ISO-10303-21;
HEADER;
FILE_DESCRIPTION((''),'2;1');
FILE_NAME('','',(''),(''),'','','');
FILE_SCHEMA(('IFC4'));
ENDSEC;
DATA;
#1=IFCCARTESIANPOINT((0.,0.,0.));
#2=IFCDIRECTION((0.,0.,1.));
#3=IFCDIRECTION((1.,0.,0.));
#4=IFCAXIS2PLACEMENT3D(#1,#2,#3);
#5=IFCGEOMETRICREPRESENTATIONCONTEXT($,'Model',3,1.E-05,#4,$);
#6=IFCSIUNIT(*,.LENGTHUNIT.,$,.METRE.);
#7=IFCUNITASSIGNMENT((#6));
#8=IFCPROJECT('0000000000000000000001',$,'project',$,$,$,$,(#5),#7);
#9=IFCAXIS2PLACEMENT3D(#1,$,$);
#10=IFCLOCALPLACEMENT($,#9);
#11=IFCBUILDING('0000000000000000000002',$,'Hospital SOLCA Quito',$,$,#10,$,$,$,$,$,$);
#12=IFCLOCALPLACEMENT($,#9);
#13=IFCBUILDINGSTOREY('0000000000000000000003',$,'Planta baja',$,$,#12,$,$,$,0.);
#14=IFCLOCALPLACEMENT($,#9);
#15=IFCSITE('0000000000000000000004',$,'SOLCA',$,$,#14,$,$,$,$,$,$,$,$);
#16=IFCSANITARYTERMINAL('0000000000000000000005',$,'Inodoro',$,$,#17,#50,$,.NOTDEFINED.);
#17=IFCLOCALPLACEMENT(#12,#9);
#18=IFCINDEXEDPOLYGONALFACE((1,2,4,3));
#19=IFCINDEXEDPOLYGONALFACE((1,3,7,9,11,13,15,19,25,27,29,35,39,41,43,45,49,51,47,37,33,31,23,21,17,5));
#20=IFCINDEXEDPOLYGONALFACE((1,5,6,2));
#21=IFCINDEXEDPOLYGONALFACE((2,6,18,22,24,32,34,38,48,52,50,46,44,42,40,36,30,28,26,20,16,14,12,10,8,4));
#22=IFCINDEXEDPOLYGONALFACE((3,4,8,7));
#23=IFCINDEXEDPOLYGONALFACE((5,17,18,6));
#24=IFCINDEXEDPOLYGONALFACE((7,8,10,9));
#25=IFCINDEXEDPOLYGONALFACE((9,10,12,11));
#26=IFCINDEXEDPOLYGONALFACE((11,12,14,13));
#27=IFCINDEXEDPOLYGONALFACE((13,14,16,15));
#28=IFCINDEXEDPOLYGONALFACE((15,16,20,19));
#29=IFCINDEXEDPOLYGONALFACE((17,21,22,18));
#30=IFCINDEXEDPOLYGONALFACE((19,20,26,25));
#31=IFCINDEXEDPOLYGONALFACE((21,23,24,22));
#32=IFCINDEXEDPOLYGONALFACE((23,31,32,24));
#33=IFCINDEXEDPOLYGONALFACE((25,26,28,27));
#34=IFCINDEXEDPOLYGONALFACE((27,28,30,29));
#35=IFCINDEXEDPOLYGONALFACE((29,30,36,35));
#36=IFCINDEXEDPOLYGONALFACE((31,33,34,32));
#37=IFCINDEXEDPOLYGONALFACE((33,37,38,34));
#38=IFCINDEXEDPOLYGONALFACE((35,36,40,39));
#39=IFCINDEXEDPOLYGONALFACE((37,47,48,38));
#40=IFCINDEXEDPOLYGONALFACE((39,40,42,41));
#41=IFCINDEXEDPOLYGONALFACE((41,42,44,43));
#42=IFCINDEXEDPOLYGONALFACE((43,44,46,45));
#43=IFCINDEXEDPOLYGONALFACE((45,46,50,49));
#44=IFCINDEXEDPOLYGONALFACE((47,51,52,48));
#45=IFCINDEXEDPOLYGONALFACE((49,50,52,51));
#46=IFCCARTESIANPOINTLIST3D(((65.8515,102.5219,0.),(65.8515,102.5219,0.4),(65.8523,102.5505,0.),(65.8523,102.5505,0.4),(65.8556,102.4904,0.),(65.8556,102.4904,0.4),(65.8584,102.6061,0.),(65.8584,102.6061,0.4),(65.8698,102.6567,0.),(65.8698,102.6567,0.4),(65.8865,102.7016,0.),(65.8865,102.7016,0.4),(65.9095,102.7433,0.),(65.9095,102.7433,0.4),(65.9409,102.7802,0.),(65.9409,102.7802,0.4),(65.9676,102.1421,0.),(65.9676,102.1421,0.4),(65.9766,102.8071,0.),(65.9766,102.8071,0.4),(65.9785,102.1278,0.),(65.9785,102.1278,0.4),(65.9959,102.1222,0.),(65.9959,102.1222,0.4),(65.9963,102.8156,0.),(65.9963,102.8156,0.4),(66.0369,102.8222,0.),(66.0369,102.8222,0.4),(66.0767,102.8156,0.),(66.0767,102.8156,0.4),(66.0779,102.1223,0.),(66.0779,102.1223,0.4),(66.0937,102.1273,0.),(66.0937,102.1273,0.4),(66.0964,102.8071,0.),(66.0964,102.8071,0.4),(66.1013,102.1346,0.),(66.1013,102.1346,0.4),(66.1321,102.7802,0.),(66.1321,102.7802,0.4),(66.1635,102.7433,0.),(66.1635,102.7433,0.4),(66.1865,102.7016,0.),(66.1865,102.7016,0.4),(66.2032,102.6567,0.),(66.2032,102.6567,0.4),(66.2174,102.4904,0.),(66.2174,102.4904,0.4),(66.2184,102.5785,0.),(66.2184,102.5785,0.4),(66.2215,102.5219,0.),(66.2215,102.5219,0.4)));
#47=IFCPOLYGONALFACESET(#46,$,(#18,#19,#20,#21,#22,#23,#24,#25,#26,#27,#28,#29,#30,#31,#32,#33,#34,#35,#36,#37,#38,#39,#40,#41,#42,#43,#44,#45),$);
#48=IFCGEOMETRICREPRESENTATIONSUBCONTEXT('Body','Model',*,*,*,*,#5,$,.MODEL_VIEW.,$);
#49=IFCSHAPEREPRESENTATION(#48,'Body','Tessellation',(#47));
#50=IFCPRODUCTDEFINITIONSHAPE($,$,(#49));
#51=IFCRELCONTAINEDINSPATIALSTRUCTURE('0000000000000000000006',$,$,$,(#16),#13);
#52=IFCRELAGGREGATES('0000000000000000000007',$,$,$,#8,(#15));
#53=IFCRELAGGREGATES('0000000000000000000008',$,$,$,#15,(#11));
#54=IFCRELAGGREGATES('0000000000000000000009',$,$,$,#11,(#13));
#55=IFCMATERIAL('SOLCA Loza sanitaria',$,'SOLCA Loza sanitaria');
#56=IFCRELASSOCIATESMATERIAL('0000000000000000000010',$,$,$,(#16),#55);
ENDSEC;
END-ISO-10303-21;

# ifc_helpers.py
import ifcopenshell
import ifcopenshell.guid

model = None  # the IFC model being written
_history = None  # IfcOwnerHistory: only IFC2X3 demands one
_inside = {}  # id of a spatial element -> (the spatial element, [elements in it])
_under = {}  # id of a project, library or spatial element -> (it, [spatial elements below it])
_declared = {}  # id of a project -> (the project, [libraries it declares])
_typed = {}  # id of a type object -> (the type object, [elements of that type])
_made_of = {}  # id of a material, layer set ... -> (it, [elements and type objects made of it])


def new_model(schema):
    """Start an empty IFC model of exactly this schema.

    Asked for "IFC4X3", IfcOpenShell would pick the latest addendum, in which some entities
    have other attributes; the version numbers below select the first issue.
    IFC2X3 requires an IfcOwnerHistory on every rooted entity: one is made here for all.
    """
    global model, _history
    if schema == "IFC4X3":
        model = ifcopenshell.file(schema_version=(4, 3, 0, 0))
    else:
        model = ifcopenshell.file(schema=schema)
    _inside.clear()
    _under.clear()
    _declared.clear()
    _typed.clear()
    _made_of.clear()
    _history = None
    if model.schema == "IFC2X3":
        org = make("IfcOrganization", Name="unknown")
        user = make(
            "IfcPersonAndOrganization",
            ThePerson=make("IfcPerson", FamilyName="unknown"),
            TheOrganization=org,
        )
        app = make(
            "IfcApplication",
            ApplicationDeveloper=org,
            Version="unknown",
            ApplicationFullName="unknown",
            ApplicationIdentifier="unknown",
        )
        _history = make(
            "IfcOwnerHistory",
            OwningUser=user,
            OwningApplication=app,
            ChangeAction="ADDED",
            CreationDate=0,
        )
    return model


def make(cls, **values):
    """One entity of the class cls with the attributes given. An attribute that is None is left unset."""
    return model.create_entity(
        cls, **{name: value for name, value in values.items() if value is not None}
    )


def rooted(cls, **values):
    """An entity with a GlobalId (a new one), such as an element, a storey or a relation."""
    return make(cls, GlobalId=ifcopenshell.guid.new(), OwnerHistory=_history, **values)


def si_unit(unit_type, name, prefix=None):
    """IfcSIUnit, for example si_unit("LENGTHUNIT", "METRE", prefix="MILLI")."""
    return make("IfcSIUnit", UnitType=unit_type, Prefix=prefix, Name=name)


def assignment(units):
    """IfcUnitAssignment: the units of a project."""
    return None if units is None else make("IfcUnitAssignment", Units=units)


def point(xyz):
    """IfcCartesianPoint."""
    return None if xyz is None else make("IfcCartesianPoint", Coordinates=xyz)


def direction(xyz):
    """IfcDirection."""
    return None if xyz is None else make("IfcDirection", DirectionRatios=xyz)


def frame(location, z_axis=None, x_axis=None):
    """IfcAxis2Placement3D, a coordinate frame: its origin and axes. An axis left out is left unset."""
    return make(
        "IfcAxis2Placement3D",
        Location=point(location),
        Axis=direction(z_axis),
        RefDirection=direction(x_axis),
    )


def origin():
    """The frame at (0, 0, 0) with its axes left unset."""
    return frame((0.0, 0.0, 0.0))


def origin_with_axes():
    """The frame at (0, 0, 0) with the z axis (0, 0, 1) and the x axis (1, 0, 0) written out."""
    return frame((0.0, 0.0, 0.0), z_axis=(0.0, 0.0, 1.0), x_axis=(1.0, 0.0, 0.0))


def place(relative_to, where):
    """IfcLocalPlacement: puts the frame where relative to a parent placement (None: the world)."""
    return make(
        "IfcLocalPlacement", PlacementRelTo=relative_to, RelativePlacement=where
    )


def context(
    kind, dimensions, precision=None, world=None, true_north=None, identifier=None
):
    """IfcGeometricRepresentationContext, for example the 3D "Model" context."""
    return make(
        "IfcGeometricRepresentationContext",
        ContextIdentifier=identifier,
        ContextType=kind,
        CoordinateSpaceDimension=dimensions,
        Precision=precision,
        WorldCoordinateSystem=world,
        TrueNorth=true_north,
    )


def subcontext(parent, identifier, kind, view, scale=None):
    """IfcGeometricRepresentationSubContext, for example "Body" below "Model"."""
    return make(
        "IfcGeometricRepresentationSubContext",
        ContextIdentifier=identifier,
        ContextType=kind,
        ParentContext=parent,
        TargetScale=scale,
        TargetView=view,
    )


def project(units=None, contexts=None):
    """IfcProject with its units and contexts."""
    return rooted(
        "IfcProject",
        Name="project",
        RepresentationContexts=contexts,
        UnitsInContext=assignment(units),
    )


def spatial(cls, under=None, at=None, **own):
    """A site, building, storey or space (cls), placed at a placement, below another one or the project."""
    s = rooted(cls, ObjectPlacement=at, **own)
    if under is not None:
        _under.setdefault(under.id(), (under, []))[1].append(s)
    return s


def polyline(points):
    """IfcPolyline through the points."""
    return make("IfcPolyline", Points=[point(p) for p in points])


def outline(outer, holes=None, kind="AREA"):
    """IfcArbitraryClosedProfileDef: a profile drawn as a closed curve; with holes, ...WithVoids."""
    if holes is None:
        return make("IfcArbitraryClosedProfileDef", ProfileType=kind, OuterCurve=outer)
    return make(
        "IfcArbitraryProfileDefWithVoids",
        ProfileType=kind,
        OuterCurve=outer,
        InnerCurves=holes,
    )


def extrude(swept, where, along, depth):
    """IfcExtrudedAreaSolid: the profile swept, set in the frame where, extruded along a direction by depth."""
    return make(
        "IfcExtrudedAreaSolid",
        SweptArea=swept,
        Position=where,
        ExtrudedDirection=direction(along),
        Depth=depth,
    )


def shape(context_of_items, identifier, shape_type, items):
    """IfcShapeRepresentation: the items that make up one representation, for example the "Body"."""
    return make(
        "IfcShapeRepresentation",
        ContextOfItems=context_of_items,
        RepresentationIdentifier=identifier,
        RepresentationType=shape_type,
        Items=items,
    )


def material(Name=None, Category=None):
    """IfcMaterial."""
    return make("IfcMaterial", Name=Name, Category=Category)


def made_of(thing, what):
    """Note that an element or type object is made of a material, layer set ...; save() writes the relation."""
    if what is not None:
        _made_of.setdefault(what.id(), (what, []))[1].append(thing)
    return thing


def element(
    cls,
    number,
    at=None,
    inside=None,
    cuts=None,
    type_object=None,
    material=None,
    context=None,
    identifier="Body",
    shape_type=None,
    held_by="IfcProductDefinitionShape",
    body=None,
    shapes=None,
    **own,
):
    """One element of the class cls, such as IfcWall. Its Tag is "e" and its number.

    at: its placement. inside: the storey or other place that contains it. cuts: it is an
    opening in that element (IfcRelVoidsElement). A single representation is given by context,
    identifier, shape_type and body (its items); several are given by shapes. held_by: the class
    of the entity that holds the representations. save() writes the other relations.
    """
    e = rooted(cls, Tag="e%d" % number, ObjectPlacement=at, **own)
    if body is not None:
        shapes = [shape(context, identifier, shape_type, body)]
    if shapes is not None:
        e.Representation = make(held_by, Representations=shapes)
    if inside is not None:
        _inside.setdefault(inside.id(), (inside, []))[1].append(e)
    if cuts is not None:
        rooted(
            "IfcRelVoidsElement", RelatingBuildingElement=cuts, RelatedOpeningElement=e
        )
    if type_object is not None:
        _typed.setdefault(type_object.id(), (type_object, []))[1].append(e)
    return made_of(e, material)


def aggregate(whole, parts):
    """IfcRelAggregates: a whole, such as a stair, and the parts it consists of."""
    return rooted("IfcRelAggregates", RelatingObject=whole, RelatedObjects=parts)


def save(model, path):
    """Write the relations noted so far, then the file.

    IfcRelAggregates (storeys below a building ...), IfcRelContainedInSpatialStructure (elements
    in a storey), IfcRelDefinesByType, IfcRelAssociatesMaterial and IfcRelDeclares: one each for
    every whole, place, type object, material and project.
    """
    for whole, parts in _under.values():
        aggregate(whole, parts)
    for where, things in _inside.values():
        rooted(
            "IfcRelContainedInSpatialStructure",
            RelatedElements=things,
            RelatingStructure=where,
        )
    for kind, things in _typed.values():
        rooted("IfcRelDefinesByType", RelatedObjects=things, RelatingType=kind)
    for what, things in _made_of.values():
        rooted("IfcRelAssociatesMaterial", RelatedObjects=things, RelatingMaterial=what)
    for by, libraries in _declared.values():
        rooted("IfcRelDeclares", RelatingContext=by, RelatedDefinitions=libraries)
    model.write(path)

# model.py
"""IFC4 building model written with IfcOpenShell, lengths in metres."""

from ifc_helpers import new_model, si_unit, origin, origin_with_axes, place, context, subcontext, project, spatial, polyline, outline, extrude, material, element, save


model = new_model("IFC4")

# Units and contexts
model_context = context("Model", 3, precision=1e-05, world=origin_with_axes())
body_context = subcontext(model_context, "Body", "Model", "MODEL_VIEW")
ifc_project = project(units=[si_unit("LENGTHUNIT", "METRE")], contexts=[model_context])

# Site, building, storey
site_placement = place(None, origin())
site = spatial("IfcSite", under=ifc_project, at=site_placement, Name="SOLCA")
building_placement = place(None, origin())
building = spatial("IfcBuilding", under=site, at=building_placement, Name="Hospital SOLCA Quito")
storey_placement = place(None, origin())
storey = spatial("IfcBuildingStorey", under=building, at=storey_placement, Name="Planta baja", Elevation=0.0)

# Sanitary terminal
ifc_material = material(Name="SOLCA Loza sanitaria", Category="SOLCA Loza sanitaria")
sanitary_terminal_1_placement = place(storey_placement, origin_with_axes())
element("IfcSanitaryTerminal", 1, at=sanitary_terminal_1_placement, inside=storey, material=ifc_material, Name="Inodoro", PredefinedType="NOTDEFINED", context=body_context, shape_type="SweptSolid", body=[
    extrude(outline(polyline([(65.9959, 102.1222), (65.9785, 102.1278), (65.9676, 102.1421), (65.8556, 102.4904), (65.8515, 102.5219), (65.8523, 102.5505), (65.8584, 102.6061), (65.8698, 102.6567), (65.8865, 102.7016), (65.9095, 102.7433), (65.9409, 102.7802), (65.9766, 102.8071), (65.9963, 102.8156), (66.0369, 102.8222), (66.0767, 102.8156), (66.0964, 102.8071), (66.1321, 102.7802), (66.1635, 102.7433), (66.1865, 102.7016), (66.2032, 102.6567), (66.2184, 102.5785), (66.2215, 102.5219), (66.2174, 102.4904), (66.1013, 102.1346), (66.0937, 102.1273), (66.0779, 102.1223), (65.9959, 102.1222)])), origin_with_axes(), (0.0, 0.0, 1.0), 0.4),
])

save(model, "model.ifc")
